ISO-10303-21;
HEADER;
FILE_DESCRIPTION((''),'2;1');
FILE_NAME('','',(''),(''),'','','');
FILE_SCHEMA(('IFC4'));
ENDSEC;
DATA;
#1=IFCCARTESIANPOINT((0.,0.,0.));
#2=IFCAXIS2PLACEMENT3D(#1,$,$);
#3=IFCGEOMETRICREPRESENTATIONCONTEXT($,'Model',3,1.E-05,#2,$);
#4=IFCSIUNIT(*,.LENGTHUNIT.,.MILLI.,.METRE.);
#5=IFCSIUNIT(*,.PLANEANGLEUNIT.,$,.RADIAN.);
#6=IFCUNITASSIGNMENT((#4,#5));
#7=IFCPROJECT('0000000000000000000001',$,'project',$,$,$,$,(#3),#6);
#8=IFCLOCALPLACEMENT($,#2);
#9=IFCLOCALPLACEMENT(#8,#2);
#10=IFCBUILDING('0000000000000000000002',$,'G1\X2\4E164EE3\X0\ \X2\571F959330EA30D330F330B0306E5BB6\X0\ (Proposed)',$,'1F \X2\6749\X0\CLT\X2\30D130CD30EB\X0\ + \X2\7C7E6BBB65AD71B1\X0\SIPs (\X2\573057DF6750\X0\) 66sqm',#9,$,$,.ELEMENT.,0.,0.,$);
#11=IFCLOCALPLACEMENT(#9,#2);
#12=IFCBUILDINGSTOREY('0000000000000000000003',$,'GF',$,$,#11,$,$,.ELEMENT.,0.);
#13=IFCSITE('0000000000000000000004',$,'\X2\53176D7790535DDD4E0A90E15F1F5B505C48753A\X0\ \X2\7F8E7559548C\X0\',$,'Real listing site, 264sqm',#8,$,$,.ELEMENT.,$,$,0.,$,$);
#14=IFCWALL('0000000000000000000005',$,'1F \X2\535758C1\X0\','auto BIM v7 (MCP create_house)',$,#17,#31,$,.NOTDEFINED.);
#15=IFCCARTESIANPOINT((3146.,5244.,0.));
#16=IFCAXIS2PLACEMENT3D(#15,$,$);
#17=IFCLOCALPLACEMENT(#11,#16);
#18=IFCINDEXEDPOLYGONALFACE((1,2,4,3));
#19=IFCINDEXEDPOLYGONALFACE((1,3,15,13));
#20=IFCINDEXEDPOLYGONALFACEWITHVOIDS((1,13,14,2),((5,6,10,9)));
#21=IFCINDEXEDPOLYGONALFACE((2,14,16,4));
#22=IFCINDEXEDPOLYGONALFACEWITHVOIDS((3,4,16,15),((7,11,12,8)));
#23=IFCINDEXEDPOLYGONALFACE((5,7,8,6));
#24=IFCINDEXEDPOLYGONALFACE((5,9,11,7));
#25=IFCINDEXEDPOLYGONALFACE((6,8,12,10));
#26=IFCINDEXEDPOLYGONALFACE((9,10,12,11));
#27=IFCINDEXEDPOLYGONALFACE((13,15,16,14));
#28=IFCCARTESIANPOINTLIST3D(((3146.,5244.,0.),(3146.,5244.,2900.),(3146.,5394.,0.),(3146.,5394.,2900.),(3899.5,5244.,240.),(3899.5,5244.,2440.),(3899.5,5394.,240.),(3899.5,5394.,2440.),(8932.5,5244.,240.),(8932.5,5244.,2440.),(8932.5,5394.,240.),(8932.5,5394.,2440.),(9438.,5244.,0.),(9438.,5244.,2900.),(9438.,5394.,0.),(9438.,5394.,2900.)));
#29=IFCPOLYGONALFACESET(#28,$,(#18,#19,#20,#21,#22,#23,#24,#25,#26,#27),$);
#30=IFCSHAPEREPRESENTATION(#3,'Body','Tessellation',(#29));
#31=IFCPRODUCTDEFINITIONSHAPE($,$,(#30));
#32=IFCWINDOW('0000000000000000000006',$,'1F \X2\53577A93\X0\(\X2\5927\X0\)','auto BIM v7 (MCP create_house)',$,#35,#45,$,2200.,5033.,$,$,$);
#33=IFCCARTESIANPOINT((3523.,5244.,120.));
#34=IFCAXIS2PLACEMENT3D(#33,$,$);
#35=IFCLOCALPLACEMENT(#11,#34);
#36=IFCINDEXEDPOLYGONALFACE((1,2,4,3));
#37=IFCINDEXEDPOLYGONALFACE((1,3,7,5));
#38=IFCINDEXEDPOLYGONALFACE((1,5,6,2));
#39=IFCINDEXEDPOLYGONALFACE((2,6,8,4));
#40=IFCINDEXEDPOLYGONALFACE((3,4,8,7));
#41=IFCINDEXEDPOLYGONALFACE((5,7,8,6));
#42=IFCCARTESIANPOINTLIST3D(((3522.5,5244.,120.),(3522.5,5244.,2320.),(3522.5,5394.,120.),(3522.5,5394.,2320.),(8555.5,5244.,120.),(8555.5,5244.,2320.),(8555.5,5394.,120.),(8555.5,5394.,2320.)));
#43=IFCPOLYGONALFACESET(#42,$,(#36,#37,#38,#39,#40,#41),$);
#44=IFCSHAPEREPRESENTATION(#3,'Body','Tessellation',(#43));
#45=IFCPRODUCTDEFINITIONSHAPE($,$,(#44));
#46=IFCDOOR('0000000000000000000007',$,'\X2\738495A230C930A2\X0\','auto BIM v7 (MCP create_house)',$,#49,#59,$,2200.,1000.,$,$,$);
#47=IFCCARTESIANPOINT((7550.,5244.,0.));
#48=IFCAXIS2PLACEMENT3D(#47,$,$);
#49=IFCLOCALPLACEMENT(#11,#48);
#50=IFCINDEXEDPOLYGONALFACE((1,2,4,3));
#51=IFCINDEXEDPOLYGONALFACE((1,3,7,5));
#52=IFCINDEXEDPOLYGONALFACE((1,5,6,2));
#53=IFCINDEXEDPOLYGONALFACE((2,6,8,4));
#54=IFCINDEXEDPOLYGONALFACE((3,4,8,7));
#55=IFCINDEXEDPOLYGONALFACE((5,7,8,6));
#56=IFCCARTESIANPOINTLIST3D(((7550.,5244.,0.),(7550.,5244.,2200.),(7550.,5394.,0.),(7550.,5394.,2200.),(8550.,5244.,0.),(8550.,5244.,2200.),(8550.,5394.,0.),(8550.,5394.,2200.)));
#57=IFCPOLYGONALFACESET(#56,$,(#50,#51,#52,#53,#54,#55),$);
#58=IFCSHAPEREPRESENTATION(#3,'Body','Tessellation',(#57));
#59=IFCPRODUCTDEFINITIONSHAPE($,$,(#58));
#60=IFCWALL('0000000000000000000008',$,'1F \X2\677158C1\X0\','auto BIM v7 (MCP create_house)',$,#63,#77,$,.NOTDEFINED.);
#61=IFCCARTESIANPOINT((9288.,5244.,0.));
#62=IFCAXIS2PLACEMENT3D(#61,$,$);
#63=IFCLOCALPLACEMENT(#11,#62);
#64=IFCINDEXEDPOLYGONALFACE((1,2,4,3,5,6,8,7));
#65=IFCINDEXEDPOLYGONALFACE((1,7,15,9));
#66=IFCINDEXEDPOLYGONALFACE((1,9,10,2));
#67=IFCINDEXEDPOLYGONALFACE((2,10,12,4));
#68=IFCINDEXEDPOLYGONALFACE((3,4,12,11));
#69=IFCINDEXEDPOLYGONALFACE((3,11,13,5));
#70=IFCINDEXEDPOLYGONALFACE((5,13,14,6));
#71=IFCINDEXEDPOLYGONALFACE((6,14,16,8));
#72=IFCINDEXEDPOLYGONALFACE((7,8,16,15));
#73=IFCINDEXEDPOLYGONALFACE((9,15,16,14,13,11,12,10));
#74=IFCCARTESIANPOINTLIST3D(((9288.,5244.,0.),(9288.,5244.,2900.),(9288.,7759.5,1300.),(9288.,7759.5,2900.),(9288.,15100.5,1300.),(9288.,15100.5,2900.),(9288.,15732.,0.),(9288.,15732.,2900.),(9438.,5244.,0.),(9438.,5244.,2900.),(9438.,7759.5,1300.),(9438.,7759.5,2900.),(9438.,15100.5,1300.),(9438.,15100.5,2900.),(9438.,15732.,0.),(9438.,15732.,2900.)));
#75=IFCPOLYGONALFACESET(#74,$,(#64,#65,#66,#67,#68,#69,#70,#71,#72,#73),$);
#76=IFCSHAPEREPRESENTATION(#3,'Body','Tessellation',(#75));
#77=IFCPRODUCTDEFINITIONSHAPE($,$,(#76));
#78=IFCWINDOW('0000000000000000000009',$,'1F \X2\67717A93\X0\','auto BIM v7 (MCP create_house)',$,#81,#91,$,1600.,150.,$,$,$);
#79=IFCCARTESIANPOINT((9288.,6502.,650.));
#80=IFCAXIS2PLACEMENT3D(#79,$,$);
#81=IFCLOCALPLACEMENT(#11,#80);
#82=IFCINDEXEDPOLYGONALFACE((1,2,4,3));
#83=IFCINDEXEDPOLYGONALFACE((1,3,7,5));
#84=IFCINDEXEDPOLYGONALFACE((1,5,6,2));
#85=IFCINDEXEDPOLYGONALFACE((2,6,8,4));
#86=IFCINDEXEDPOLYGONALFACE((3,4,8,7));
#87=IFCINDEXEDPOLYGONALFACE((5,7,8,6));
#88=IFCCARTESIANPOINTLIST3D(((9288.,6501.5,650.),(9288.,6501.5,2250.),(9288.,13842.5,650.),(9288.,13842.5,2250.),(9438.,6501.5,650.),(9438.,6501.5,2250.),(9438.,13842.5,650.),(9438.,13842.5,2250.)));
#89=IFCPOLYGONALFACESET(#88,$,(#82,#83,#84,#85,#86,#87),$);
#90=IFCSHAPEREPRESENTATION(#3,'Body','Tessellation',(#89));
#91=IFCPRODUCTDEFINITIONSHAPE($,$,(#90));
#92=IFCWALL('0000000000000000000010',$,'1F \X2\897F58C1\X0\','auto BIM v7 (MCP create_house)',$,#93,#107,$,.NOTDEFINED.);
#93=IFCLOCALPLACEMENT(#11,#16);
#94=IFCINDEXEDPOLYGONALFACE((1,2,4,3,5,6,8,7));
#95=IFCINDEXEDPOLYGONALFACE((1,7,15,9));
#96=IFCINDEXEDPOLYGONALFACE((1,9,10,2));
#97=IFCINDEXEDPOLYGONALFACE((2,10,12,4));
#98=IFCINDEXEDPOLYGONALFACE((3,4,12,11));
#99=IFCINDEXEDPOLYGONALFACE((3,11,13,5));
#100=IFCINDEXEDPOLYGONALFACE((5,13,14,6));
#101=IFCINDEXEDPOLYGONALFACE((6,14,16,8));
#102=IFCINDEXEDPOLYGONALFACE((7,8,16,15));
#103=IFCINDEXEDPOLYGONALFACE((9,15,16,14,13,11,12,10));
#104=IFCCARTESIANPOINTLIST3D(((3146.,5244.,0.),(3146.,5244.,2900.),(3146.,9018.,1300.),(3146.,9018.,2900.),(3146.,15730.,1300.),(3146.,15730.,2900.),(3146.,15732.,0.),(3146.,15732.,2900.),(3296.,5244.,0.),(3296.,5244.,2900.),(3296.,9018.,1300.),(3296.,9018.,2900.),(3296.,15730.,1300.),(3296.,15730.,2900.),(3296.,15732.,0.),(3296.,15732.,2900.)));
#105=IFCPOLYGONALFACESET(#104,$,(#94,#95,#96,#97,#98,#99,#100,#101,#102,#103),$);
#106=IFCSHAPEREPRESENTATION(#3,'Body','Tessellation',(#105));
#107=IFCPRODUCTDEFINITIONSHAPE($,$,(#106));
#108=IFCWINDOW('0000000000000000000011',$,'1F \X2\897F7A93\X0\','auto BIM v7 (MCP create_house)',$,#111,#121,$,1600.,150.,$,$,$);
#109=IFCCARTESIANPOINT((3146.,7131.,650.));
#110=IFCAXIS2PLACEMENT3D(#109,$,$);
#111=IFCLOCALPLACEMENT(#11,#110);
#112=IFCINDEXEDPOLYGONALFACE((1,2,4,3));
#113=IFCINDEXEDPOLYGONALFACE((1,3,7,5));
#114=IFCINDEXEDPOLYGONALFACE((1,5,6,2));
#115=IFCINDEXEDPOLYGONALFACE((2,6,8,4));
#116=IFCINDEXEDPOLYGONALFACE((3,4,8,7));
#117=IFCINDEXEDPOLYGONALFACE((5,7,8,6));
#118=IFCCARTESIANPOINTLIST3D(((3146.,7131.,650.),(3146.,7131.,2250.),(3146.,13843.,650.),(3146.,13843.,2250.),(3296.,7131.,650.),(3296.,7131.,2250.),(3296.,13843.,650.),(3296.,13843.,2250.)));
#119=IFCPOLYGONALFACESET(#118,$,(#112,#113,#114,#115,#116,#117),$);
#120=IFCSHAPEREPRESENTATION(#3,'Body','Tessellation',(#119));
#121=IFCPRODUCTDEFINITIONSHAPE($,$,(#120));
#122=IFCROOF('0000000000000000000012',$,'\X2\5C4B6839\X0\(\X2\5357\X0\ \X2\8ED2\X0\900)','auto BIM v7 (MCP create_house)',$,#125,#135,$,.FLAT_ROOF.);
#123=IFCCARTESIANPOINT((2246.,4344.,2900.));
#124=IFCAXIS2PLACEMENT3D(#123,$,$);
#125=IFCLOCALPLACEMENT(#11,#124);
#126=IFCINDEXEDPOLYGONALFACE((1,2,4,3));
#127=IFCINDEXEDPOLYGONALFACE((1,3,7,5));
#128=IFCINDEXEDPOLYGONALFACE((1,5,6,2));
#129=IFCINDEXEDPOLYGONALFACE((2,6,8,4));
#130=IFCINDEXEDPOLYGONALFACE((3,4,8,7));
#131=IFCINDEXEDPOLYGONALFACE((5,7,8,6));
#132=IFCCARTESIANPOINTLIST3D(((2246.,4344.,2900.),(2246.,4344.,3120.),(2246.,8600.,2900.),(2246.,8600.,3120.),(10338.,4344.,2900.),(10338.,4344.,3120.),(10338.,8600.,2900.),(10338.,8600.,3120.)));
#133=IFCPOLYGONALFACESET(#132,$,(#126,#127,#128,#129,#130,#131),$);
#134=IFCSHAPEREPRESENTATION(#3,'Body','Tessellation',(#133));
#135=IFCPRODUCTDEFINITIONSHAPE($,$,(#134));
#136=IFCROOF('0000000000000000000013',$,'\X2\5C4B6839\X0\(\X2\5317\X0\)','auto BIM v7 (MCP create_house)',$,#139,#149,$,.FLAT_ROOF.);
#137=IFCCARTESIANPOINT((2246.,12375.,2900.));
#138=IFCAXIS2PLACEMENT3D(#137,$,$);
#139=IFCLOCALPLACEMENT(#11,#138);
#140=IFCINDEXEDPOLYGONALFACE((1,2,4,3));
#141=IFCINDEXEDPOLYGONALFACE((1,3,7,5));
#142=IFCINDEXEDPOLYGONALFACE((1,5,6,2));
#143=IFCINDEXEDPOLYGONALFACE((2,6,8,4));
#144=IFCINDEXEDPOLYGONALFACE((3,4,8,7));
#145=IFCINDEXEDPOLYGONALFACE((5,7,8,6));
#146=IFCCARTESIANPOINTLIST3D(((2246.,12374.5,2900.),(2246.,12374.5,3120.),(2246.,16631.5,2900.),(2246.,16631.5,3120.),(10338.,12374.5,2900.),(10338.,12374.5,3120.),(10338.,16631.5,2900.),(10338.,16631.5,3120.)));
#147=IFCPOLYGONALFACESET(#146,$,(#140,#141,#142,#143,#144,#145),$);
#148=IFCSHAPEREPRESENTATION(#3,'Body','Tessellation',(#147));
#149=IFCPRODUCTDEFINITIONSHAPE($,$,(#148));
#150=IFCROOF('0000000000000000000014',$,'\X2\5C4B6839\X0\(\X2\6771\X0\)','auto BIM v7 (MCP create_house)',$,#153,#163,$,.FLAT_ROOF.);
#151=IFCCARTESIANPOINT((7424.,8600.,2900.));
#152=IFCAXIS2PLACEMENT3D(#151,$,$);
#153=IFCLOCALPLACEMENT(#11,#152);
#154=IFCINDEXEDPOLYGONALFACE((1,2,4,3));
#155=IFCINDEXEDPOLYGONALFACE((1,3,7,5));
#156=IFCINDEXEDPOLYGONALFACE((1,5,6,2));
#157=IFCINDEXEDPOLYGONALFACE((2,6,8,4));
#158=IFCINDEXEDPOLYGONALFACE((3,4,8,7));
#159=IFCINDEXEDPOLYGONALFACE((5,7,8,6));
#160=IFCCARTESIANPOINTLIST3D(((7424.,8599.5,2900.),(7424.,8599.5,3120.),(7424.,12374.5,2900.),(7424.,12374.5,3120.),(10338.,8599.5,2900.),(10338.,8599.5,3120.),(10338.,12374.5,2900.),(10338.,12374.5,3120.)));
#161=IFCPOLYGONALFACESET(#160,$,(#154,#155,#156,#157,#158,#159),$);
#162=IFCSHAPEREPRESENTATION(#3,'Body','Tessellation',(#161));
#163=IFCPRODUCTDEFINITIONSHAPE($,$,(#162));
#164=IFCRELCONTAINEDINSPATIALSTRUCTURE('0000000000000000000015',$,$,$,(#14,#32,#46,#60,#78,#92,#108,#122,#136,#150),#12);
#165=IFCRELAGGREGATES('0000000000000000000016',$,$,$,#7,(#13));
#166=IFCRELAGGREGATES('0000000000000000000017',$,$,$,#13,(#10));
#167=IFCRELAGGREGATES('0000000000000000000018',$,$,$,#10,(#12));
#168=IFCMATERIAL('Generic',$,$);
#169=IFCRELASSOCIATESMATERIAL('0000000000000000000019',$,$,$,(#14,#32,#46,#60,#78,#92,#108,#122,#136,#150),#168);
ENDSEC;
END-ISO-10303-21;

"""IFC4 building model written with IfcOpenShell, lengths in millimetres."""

from ifc_helpers import new_model, si_unit, frame, frame_2d, origin, place, context, project, spatial, rectangle, extrude, material, element, fill, save


model = new_model("IFC4")

# Units and contexts
model_context = context("Model", 3, precision=1e-05, world=origin())
ifc_project = project(units=[si_unit("LENGTHUNIT", "METRE", prefix="MILLI"), si_unit("PLANEANGLEUNIT", "RADIAN")], contexts=[model_context])

# Site, building, storey
site_placement = place(None, origin())
site = spatial("IfcSite", under=ifc_project, at=site_placement, Name="北海道川上郡弟子屈町 美留和", ObjectType="Real listing site, 264sqm", CompositionType="ELEMENT", RefElevation=0.0)
building_placement = place(site_placement, origin())
building = spatial("IfcBuilding", under=site, at=building_placement, Name="G1世代 土間リビングの家 (Proposed)", ObjectType="1F 杉CLTパネル + 籾殻断熱SIPs (地域材) 66sqm", CompositionType="ELEMENT", ElevationOfRefHeight=0.0, ElevationOfTerrain=0.0)
storey_placement = place(building_placement, origin())
storey = spatial("IfcBuildingStorey", under=building, at=storey_placement, Name="GF", CompositionType="ELEMENT", Elevation=0.0)

# Shared definitions
ifc_material = material(Name="Generic")

# Wall, openings, window, door
wall_1_placement = place(storey_placement, frame((3146.0, 5244.0, 0.0)))
wall_1 = element("IfcWall", 1, at=wall_1_placement, inside=storey, material=ifc_material, Name="1F 南壁", Description="auto BIM v7 (MCP create_house)", PredefinedType="NOTDEFINED", context=model_context, shape_type="SweptSolid", body=[
    extrude(rectangle(XDim=6292.0, YDim=150.0, at=frame_2d((3146.0, 75.0))), frame((3146.0, 5244.0, 0.0)), (0.0, 0.0, 1.0), 2900.0),
])
opening_1_placement = place(storey_placement, frame((3523.0, 5244.0, 120.0)))
opening_1 = element("IfcOpeningElement", 2, at=opening_1_placement, cuts=wall_1, PredefinedType="NOTDEFINED", context=model_context, shape_type="SweptSolid", body=[
    extrude(rectangle(XDim=5033.0, YDim=150.0, at=frame_2d((2516.0, 75.0))), frame((3523.0, 5244.0, 120.0)), (0.0, 0.0, 1.0), 2200.0),
])
opening_2_placement = place(storey_placement, frame((7550.0, 5244.0, 0.0)))
opening_2 = element("IfcOpeningElement", 3, at=opening_2_placement, cuts=wall_1, PredefinedType="NOTDEFINED", context=model_context, shape_type="SweptSolid", body=[
    extrude(rectangle(XDim=1000.0, YDim=150.0, at=frame_2d((500.0, 75.0))), frame((7550.0, 5244.0, 0.0)), (0.0, 0.0, 1.0), 2200.0),
])
window_1_placement = place(storey_placement, frame((3523.0, 5244.0, 120.0)))
window_1 = element("IfcWindow", 4, at=window_1_placement, inside=storey, material=ifc_material, Name="1F 南窓(大)", Description="auto BIM v7 (MCP create_house)", OverallHeight=2200.0, OverallWidth=5033.0, context=model_context, shape_type="SweptSolid", body=[
    extrude(rectangle(XDim=5033.0, YDim=150.0, at=frame_2d((2516.0, 75.0))), frame((3523.0, 5244.0, 120.0)), (0.0, 0.0, 1.0), 2200.0),
])
fill(opening_1, window_1)
door_placement = place(storey_placement, frame((7550.0, 5244.0, 0.0)))
door = element("IfcDoor", 5, at=door_placement, inside=storey, material=ifc_material, Name="玄関ドア", Description="auto BIM v7 (MCP create_house)", OverallHeight=2200.0, OverallWidth=1000.0, context=model_context, shape_type="SweptSolid", body=[
    extrude(rectangle(XDim=1000.0, YDim=150.0, at=frame_2d((500.0, 75.0))), frame((7550.0, 5244.0, 0.0)), (0.0, 0.0, 1.0), 2200.0),
])
fill(opening_2, door)

# Walls, openings, windows
wall_2_placement = place(storey_placement, frame((9288.0, 5244.0, 0.0)))
wall_2 = element("IfcWall", 6, at=wall_2_placement, inside=storey, material=ifc_material, Name="1F 東壁", Description="auto BIM v7 (MCP create_house)", PredefinedType="NOTDEFINED", context=model_context, shape_type="SweptSolid", body=[
    extrude(rectangle(XDim=150.0, YDim=10488.0, at=frame_2d((75.0, 5244.0))), frame((9288.0, 5244.0, 0.0)), (0.0, 0.0, 1.0), 2900.0),
])
opening_3_placement = place(storey_placement, frame((9288.0, 6502.0, 650.0)))
opening_3 = element("IfcOpeningElement", 7, at=opening_3_placement, cuts=wall_2, PredefinedType="NOTDEFINED", context=model_context, shape_type="SweptSolid", body=[
    extrude(rectangle(XDim=150.0, YDim=7341.0, at=frame_2d((75.0, 3670.0))), frame((9288.0, 6502.0, 650.0)), (0.0, 0.0, 1.0), 1600.0),
])
window_2_placement = place(storey_placement, frame((9288.0, 6502.0, 650.0)))
window_2 = element("IfcWindow", 8, at=window_2_placement, inside=storey, material=ifc_material, Name="1F 東窓", Description="auto BIM v7 (MCP create_house)", OverallHeight=1600.0, OverallWidth=150.0, context=model_context, shape_type="SweptSolid", body=[
    extrude(rectangle(XDim=150.0, YDim=7341.0, at=frame_2d((75.0, 3670.0))), frame((9288.0, 6502.0, 650.0)), (0.0, 0.0, 1.0), 1600.0),
])
fill(opening_3, window_2)
wall_3_placement = place(storey_placement, frame((3146.0, 5244.0, 0.0)))
wall_3 = element("IfcWall", 9, at=wall_3_placement, inside=storey, material=ifc_material, Name="1F 西壁", Description="auto BIM v7 (MCP create_house)", PredefinedType="NOTDEFINED", context=model_context, shape_type="SweptSolid", body=[
    extrude(rectangle(XDim=150.0, YDim=10488.0, at=frame_2d((75.0, 5244.0))), frame((3146.0, 5244.0, 0.0)), (0.0, 0.0, 1.0), 2900.0),
])
opening_4_placement = place(storey_placement, frame((3146.0, 7131.0, 650.0)))
opening_4 = element("IfcOpeningElement", 10, at=opening_4_placement, cuts=wall_3, PredefinedType="NOTDEFINED", context=model_context, shape_type="SweptSolid", body=[
    extrude(rectangle(XDim=150.0, YDim=6712.0, at=frame_2d((75.0, 3356.0))), frame((3146.0, 7131.0, 650.0)), (0.0, 0.0, 1.0), 1600.0),
])
window_3_placement = place(storey_placement, frame((3146.0, 7131.0, 650.0)))
window_3 = element("IfcWindow", 11, at=window_3_placement, inside=storey, material=ifc_material, Name="1F 西窓", Description="auto BIM v7 (MCP create_house)", OverallHeight=1600.0, OverallWidth=150.0, context=model_context, shape_type="SweptSolid", body=[
    extrude(rectangle(XDim=150.0, YDim=6712.0, at=frame_2d((75.0, 3356.0))), frame((3146.0, 7131.0, 650.0)), (0.0, 0.0, 1.0), 1600.0),
])
fill(opening_4, window_3)

# Roofs
roof_1_placement = place(storey_placement, frame((2246.0, 4344.0, 2900.0)))
element("IfcRoof", 12, at=roof_1_placement, inside=storey, material=ifc_material, Name="屋根(南 軒900)", Description="auto BIM v7 (MCP create_house)", PredefinedType="FLAT_ROOF", context=model_context, shape_type="SweptSolid", body=[
    extrude(rectangle(XDim=8092.0, YDim=4256.0, at=frame_2d((4046.0, 2128.0))), frame((2246.0, 4344.0, 2900.0)), (0.0, 0.0, 1.0), 220.0),
])
roof_2_placement = place(storey_placement, frame((2246.0, 12375.0, 2900.0)))
element("IfcRoof", 13, at=roof_2_placement, inside=storey, material=ifc_material, Name="屋根(北)", Description="auto BIM v7 (MCP create_house)", PredefinedType="FLAT_ROOF", context=model_context, shape_type="SweptSolid", body=[
    extrude(rectangle(XDim=8092.0, YDim=4257.0, at=frame_2d((4046.0, 2128.0))), frame((2246.0, 12375.0, 2900.0)), (0.0, 0.0, 1.0), 220.0),
])
roof_3_placement = place(storey_placement, frame((7424.0, 8600.0, 2900.0)))
element("IfcRoof", 14, at=roof_3_placement, inside=storey, material=ifc_material, Name="屋根(東)", Description="auto BIM v7 (MCP create_house)", PredefinedType="FLAT_ROOF", context=model_context, shape_type="SweptSolid", body=[
    extrude(rectangle(XDim=2914.0, YDim=3775.0, at=frame_2d((1457.0, 1887.0))), frame((7424.0, 8600.0, 2900.0)), (0.0, 0.0, 1.0), 220.0),
])

save(model, "model.ifc")
